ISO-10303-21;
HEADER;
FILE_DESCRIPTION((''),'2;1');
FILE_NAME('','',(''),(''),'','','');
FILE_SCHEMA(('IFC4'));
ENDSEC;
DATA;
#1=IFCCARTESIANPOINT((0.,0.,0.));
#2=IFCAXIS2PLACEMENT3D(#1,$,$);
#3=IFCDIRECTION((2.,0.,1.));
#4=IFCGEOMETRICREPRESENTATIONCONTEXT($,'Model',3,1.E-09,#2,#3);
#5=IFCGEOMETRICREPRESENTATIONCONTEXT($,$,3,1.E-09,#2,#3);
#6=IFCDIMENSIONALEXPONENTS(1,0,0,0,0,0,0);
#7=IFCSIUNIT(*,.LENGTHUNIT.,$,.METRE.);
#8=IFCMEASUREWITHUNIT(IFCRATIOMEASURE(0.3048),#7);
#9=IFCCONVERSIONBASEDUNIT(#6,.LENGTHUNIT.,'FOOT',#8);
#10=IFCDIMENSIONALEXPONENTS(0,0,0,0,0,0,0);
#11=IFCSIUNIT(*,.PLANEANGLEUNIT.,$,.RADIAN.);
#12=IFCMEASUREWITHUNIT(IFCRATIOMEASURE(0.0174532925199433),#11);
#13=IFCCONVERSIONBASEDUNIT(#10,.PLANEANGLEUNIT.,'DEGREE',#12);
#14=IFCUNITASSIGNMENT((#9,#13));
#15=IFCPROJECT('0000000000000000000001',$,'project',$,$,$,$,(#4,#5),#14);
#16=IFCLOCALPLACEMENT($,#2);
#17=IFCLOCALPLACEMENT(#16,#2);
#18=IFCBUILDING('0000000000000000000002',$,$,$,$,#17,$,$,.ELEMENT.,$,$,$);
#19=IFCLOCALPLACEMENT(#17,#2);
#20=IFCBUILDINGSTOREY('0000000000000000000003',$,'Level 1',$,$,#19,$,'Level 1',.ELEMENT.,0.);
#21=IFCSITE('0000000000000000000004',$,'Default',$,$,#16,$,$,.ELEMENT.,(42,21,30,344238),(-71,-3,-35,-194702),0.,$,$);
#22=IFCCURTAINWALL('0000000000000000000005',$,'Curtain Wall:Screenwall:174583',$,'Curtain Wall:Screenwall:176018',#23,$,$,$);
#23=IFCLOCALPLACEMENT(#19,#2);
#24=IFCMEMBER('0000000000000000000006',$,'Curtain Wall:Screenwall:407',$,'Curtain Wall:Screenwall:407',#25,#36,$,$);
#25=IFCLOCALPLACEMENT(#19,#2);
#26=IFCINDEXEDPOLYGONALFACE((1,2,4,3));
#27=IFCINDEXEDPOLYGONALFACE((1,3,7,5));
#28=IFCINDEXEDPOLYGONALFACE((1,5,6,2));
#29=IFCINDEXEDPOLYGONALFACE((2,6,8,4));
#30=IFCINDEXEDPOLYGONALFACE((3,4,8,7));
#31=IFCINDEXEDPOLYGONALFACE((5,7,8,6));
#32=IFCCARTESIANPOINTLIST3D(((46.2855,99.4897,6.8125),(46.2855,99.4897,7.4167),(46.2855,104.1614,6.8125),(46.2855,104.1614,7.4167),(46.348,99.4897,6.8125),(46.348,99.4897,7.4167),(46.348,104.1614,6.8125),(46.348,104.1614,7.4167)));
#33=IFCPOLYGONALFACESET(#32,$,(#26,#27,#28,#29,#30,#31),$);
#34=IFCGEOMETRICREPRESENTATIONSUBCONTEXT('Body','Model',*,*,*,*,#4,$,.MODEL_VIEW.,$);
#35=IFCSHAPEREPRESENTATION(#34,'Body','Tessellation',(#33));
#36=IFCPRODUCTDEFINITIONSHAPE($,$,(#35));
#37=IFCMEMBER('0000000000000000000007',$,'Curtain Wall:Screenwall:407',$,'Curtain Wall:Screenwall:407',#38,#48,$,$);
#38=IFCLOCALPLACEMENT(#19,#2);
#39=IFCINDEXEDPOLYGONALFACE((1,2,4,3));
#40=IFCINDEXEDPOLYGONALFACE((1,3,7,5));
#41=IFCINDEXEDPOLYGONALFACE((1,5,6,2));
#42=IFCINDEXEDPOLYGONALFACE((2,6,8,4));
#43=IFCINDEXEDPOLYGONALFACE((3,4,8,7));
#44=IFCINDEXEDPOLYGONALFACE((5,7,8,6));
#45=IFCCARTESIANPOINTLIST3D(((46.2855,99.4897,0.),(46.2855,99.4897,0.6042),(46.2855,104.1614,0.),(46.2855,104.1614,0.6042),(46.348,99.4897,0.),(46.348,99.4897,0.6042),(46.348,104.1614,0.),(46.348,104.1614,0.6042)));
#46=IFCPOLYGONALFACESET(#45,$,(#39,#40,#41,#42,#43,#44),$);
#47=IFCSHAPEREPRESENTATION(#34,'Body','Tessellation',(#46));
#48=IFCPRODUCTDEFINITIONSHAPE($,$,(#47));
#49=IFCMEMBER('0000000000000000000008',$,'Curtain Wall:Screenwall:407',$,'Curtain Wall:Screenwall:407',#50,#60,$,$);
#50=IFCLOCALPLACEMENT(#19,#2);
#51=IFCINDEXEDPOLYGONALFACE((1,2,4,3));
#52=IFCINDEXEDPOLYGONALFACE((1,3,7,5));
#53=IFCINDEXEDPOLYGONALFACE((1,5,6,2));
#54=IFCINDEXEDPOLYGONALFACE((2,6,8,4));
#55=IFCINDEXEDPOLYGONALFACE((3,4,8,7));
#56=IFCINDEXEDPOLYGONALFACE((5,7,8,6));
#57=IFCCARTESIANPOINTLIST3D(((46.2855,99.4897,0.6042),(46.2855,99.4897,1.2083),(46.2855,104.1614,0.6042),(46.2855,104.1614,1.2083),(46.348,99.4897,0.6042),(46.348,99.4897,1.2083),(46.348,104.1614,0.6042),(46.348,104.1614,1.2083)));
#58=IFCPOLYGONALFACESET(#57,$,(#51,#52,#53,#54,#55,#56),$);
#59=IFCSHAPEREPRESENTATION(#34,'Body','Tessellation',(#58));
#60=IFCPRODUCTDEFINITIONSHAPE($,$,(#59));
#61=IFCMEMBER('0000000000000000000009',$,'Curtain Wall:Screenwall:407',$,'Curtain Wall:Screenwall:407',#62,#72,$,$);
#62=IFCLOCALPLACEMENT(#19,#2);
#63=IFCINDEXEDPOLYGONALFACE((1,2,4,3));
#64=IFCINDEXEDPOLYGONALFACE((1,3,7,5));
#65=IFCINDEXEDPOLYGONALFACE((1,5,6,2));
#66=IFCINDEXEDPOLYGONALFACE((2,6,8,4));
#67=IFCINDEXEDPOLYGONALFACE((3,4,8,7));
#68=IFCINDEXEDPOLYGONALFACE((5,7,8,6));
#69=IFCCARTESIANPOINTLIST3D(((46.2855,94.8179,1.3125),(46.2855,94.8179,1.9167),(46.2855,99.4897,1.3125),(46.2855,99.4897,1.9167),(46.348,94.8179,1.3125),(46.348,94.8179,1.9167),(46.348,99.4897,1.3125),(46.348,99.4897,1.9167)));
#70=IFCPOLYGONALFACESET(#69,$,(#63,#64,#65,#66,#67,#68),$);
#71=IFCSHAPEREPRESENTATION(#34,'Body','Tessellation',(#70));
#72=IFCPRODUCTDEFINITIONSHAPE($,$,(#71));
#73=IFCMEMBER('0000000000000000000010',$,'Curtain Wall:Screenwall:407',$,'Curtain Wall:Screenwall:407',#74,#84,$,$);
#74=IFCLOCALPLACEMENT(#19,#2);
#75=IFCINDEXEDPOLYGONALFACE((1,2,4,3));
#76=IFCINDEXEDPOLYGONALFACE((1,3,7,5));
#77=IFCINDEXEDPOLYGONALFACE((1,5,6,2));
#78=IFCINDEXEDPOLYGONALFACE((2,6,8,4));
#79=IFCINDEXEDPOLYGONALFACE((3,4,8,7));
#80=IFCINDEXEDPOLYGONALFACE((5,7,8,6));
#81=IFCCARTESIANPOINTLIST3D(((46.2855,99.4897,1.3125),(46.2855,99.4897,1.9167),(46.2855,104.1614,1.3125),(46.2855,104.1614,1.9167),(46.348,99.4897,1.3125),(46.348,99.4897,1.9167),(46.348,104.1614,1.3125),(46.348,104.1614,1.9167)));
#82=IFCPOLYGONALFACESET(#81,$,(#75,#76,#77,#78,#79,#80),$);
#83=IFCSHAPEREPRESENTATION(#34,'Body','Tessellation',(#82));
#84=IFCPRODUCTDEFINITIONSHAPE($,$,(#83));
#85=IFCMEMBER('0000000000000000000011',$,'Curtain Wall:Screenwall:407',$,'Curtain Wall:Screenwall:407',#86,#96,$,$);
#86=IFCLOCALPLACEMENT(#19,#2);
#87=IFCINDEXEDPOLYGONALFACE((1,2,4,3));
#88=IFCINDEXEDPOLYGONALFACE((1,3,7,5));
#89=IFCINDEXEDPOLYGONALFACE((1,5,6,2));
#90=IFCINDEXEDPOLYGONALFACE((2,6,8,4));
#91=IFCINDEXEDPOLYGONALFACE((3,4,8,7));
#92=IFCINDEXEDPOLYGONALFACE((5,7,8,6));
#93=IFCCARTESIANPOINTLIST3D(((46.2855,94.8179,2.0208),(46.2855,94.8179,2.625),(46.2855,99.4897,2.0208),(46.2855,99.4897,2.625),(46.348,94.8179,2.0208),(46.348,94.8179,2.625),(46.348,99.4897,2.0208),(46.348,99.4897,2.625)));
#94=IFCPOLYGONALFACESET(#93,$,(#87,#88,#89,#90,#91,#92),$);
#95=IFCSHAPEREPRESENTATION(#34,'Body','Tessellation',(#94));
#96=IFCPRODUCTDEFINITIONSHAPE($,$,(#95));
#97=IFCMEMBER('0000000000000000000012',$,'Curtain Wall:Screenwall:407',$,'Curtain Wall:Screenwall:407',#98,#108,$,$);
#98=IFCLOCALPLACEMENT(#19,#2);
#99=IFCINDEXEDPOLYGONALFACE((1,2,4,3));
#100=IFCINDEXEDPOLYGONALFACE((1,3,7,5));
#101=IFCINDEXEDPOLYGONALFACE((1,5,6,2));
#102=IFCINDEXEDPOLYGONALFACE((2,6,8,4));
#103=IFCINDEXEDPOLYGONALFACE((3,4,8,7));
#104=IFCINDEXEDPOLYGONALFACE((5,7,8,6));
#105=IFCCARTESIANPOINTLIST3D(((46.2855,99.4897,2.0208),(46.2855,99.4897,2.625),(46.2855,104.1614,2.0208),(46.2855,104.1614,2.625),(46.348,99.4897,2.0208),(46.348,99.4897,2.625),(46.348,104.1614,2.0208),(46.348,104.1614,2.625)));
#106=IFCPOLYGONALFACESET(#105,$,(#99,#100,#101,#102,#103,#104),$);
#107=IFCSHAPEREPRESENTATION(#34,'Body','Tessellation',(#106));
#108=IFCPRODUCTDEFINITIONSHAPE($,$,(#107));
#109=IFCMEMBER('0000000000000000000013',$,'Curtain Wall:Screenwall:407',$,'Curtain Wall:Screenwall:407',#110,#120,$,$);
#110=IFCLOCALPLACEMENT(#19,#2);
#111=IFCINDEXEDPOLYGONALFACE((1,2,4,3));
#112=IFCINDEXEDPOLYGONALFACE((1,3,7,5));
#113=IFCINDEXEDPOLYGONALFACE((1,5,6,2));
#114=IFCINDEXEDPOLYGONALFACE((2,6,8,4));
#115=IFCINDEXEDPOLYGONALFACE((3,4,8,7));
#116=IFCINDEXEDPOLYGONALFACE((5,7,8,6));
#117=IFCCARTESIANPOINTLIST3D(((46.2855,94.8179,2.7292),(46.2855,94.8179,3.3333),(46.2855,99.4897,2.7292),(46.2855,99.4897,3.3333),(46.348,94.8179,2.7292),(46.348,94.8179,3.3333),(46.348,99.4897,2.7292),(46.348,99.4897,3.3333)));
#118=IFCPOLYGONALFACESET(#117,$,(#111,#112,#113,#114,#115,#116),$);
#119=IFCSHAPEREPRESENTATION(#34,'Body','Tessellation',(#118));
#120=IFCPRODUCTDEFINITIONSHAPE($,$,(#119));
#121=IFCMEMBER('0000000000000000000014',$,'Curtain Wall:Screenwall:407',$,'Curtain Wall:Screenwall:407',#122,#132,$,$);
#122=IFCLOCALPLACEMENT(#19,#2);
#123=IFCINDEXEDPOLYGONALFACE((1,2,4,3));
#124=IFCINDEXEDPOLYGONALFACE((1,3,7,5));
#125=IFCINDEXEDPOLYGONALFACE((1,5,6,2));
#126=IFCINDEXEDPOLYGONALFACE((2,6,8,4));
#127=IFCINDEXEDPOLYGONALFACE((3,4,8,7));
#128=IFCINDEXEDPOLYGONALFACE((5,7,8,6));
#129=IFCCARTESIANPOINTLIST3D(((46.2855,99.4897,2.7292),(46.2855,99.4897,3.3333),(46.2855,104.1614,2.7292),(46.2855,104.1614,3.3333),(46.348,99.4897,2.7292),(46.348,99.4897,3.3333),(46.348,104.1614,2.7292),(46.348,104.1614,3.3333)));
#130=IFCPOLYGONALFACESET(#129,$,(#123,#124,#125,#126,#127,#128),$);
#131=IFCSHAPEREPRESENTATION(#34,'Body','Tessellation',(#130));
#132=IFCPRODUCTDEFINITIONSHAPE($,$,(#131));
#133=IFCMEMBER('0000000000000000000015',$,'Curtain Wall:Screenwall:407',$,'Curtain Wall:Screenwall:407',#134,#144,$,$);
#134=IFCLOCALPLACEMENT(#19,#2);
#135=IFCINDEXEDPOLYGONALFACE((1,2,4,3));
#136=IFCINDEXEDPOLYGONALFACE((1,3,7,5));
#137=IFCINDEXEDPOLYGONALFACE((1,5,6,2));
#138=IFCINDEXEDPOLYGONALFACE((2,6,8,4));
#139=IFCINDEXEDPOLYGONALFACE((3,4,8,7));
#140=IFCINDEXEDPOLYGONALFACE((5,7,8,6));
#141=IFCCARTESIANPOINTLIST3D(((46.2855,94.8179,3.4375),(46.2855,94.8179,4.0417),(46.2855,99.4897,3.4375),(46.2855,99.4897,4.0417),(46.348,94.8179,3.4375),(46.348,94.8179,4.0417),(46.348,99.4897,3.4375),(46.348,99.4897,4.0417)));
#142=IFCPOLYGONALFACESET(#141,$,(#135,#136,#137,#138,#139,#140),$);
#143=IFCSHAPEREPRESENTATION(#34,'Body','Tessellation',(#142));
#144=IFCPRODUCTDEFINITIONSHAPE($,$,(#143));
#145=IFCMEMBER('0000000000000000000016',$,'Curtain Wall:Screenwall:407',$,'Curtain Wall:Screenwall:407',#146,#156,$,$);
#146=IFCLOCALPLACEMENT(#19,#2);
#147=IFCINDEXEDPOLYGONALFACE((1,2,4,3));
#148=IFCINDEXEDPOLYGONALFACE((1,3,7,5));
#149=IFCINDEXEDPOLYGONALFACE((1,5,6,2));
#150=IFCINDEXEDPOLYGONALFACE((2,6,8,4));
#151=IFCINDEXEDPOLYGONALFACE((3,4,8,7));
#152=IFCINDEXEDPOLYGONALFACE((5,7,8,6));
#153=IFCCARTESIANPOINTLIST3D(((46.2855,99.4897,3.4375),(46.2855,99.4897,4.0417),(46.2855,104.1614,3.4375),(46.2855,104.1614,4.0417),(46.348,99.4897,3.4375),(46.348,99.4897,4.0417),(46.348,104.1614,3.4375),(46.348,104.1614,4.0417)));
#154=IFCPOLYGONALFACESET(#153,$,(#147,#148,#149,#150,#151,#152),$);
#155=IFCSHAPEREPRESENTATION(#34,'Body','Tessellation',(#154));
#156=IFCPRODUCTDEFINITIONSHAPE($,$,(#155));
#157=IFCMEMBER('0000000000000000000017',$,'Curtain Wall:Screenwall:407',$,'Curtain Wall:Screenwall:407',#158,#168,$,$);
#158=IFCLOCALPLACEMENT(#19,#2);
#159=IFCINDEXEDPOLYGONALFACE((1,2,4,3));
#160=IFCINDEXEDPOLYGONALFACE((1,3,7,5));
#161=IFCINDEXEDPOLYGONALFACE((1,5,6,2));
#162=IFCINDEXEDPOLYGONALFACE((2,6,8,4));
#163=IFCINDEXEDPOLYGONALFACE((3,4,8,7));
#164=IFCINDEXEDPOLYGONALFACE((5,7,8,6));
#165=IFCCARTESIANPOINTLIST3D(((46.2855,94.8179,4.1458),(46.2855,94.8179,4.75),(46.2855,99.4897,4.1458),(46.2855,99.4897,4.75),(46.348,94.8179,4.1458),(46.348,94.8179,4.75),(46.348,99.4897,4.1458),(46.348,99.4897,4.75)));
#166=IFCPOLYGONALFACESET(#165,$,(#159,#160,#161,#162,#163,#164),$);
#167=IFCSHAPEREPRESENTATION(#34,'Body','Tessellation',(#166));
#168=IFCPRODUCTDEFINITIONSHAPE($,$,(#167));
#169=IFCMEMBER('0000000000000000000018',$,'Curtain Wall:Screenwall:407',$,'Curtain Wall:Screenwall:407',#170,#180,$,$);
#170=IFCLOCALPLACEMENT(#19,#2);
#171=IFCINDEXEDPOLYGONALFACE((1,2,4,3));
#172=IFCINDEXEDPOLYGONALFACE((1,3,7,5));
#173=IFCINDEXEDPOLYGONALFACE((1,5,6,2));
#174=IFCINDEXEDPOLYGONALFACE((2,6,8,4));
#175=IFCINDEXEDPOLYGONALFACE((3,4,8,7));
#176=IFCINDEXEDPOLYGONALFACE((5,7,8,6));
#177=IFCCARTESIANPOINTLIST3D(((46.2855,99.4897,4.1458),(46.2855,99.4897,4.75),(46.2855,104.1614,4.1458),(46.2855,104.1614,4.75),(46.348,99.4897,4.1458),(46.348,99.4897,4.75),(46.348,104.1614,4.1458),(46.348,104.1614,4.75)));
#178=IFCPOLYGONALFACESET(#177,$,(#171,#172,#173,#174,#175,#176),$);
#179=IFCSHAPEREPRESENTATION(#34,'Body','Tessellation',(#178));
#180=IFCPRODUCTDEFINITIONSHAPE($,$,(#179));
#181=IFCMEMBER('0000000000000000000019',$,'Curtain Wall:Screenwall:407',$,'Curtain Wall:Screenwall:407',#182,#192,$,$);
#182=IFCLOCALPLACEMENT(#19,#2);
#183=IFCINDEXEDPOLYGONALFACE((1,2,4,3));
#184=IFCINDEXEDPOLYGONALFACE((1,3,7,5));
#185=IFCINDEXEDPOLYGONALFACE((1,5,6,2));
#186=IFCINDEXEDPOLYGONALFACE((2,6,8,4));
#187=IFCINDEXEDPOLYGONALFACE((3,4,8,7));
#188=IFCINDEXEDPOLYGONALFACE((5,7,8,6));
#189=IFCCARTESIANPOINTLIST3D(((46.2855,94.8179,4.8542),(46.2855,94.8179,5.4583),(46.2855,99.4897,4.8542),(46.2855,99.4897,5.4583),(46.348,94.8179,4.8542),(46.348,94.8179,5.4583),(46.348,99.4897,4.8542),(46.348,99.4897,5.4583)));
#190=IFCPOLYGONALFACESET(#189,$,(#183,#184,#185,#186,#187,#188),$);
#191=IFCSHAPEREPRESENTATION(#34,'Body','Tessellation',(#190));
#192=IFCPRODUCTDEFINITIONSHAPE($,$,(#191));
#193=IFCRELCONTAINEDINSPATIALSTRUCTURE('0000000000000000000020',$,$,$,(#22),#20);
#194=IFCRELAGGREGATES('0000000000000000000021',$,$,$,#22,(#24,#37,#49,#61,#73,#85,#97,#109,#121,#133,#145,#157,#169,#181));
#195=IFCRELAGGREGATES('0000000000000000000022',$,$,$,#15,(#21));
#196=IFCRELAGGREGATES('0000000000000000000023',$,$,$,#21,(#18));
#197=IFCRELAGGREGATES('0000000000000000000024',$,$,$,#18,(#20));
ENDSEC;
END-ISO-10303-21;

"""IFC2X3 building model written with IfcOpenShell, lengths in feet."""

from ifc_helpers import new_model, entity, si_unit, converted_unit, direction, frame, frame_2d, origin, place, context, subcontext, project, spatial, rectangle, extrude, element, aggregate, save


model = new_model("IFC2X3")

# Units and contexts
model_context = context("Model", 3, precision=1e-09, world=origin(), true_north=direction((2.0, 0.0, 1.0)))
context_of_model = context(None, 3, precision=1e-09, world=origin(), true_north=direction((2.0, 0.0, 1.0)))
body_context = subcontext(model_context, "Body", "Model", "MODEL_VIEW")
ifc_project = project(units=[converted_unit("LENGTHUNIT", "FOOT", entity("IfcRatioMeasure", 0.3048), si_unit("LENGTHUNIT", "METRE"), dimensions=[1, 0, 0, 0, 0, 0, 0]), converted_unit("PLANEANGLEUNIT", "DEGREE", entity("IfcRatioMeasure", 0.0174532925199433), si_unit("PLANEANGLEUNIT", "RADIAN"), dimensions=[0, 0, 0, 0, 0, 0, 0])], contexts=[model_context, context_of_model])

# Site, building, storey
site_placement = place(None, origin())
site = spatial("IfcSite", under=ifc_project, at=site_placement, Name="Default", CompositionType="ELEMENT", RefLatitude=(42, 21, 30, 344238), RefLongitude=(-71, -3, -35, -194702), RefElevation=0.0)
building_placement = place(site_placement, origin())
building = spatial("IfcBuilding", under=site, at=building_placement, CompositionType="ELEMENT")
storey_placement = place(building_placement, origin())
storey = spatial("IfcBuildingStorey", under=building, at=storey_placement, Name="Level 1", LongName="Level 1", CompositionType="ELEMENT", Elevation=0.0)

# Curtain wall, members
curtain_wall_1_placement = place(storey_placement, origin())
curtain_wall_1 = element("IfcCurtainWall", 1, at=curtain_wall_1_placement, inside=storey, Name="Curtain Wall:Screenwall:174583", ObjectType="Curtain Wall:Screenwall:176018")
member_1_placement = place(curtain_wall_1_placement, frame((46.2855, 99.4897, 6.8125)))
member_1 = element("IfcMember", 2, at=member_1_placement, Name="Curtain Wall:Screenwall:407", ObjectType="Curtain Wall:Screenwall:407", context=body_context, shape_type="SweptSolid", body=[
    extrude(rectangle(XDim=4.6717, YDim=0.0625, at=frame_2d((0.0, 0.0), x_axis=(1.0, 0.0))), frame((0.0313, 2.3359, 0.0), z_axis=(0.0, 0.0, 1.0), x_axis=(0.0, -1.0, 0.0)), (0.0, 0.0, 1.0), 0.6042),
])
member_2_placement = place(curtain_wall_1_placement, frame((46.2855, 99.4897, 0.0)))
member_2 = element("IfcMember", 3, at=member_2_placement, Name="Curtain Wall:Screenwall:407", ObjectType="Curtain Wall:Screenwall:407", context=body_context, shape_type="SweptSolid", body=[
    extrude(rectangle(XDim=4.6717, YDim=0.0625, at=frame_2d((0.0, 0.0), x_axis=(1.0, 0.0))), frame((0.0312, 2.3359, 0.0), z_axis=(0.0, 0.0, 1.0), x_axis=(0.0, 1.0, 0.0)), (0.0, 0.0, 1.0), 0.6042),
])
member_3_placement = place(curtain_wall_1_placement, frame((46.2855, 99.4897, 0.6042)))
member_3 = element("IfcMember", 4, at=member_3_placement, Name="Curtain Wall:Screenwall:407", ObjectType="Curtain Wall:Screenwall:407", context=body_context, shape_type="SweptSolid", body=[
    extrude(rectangle(XDim=4.6717, YDim=0.0625, at=frame_2d((0.0, 0.0), x_axis=(1.0, 0.0))), frame((0.0313, 2.3359, 0.0), z_axis=(0.0, 0.0, 1.0), x_axis=(0.0, -1.0, 0.0)), (0.0, 0.0, 1.0), 0.6042),
])
member_4_placement = place(curtain_wall_1_placement, frame((46.2855, 94.8179, 1.3125)))
member_4 = element("IfcMember", 5, at=member_4_placement, Name="Curtain Wall:Screenwall:407", ObjectType="Curtain Wall:Screenwall:407", context=body_context, shape_type="SweptSolid", body=[
    extrude(rectangle(XDim=4.6717, YDim=0.0625, at=frame_2d((0.0, 0.0), x_axis=(1.0, 0.0))), frame((0.0312, 2.3359, 0.0), z_axis=(0.0, 0.0, 1.0), x_axis=(0.0, -1.0, 0.0)), (0.0, 0.0, 1.0), 0.6042),
])
member_5_placement = place(curtain_wall_1_placement, frame((46.2855, 99.4897, 1.3125)))
member_5 = element("IfcMember", 6, at=member_5_placement, Name="Curtain Wall:Screenwall:407", ObjectType="Curtain Wall:Screenwall:407", context=body_context, shape_type="SweptSolid", body=[
    extrude(rectangle(XDim=4.6717, YDim=0.0625, at=frame_2d((0.0, 0.0), x_axis=(1.0, 0.0))), frame((0.0313, 2.3359, 0.0), z_axis=(0.0, 0.0, 1.0), x_axis=(0.0, -1.0, 0.0)), (0.0, 0.0, 1.0), 0.6042),
])
member_6_placement = place(curtain_wall_1_placement, frame((46.2855, 94.8179, 2.0208)))
member_6 = element("IfcMember", 7, at=member_6_placement, Name="Curtain Wall:Screenwall:407", ObjectType="Curtain Wall:Screenwall:407", context=body_context, shape_type="SweptSolid", body=[
    extrude(rectangle(XDim=4.6717, YDim=0.0625, at=frame_2d((0.0, 0.0), x_axis=(1.0, 0.0))), frame((0.0312, 2.3359, 0.0), z_axis=(0.0, 0.0, 1.0), x_axis=(0.0, -1.0, 0.0)), (0.0, 0.0, 1.0), 0.6042),
])
member_7_placement = place(curtain_wall_1_placement, frame((46.2855, 99.4897, 2.0208)))
member_7 = element("IfcMember", 8, at=member_7_placement, Name="Curtain Wall:Screenwall:407", ObjectType="Curtain Wall:Screenwall:407", context=body_context, shape_type="SweptSolid", body=[
    extrude(rectangle(XDim=4.6717, YDim=0.0625, at=frame_2d((0.0, 0.0), x_axis=(1.0, 0.0))), frame((0.0313, 2.3359, 0.0), z_axis=(0.0, 0.0, 1.0), x_axis=(0.0, -1.0, 0.0)), (0.0, 0.0, 1.0), 0.6042),
])
member_8_placement = place(curtain_wall_1_placement, frame((46.2855, 94.8179, 2.7292)))
member_8 = element("IfcMember", 9, at=member_8_placement, Name="Curtain Wall:Screenwall:407", ObjectType="Curtain Wall:Screenwall:407", context=body_context, shape_type="SweptSolid", body=[
    extrude(rectangle(XDim=4.6717, YDim=0.0625, at=frame_2d((0.0, 0.0), x_axis=(1.0, 0.0))), frame((0.0312, 2.3359, 0.0), z_axis=(0.0, 0.0, 1.0), x_axis=(0.0, -1.0, 0.0)), (0.0, 0.0, 1.0), 0.6042),
])
member_9_placement = place(curtain_wall_1_placement, frame((46.2855, 99.4897, 2.7292)))
member_9 = element("IfcMember", 10, at=member_9_placement, Name="Curtain Wall:Screenwall:407", ObjectType="Curtain Wall:Screenwall:407", context=body_context, shape_type="SweptSolid", body=[
    extrude(rectangle(XDim=4.6717, YDim=0.0625, at=frame_2d((0.0, 0.0), x_axis=(1.0, 0.0))), frame((0.0313, 2.3359, 0.0), z_axis=(0.0, 0.0, 1.0), x_axis=(0.0, -1.0, 0.0)), (0.0, 0.0, 1.0), 0.6042),
])
member_10_placement = place(curtain_wall_1_placement, frame((46.2855, 94.8179, 3.4375)))
member_10 = element("IfcMember", 11, at=member_10_placement, Name="Curtain Wall:Screenwall:407", ObjectType="Curtain Wall:Screenwall:407", context=body_context, shape_type="SweptSolid", body=[
    extrude(rectangle(XDim=4.6717, YDim=0.0625, at=frame_2d((0.0, 0.0), x_axis=(1.0, 0.0))), frame((0.0312, 2.3359, 0.0), z_axis=(0.0, 0.0, 1.0), x_axis=(0.0, -1.0, 0.0)), (0.0, 0.0, 1.0), 0.6042),
])
member_11_placement = place(curtain_wall_1_placement, frame((46.2855, 99.4897, 3.4375)))
member_11 = element("IfcMember", 12, at=member_11_placement, Name="Curtain Wall:Screenwall:407", ObjectType="Curtain Wall:Screenwall:407", context=body_context, shape_type="SweptSolid", body=[
    extrude(rectangle(XDim=4.6717, YDim=0.0625, at=frame_2d((0.0, 0.0), x_axis=(1.0, 0.0))), frame((0.0313, 2.3359, 0.0), z_axis=(0.0, 0.0, 1.0), x_axis=(0.0, -1.0, 0.0)), (0.0, 0.0, 1.0), 0.6042),
])
member_12_placement = place(curtain_wall_1_placement, frame((46.2855, 94.8179, 4.1458)))
member_12 = element("IfcMember", 13, at=member_12_placement, Name="Curtain Wall:Screenwall:407", ObjectType="Curtain Wall:Screenwall:407", context=body_context, shape_type="SweptSolid", body=[
    extrude(rectangle(XDim=4.6717, YDim=0.0625, at=frame_2d((0.0, 0.0), x_axis=(1.0, 0.0))), frame((0.0312, 2.3359, 0.0), z_axis=(0.0, 0.0, 1.0), x_axis=(0.0, -1.0, 0.0)), (0.0, 0.0, 1.0), 0.6042),
])
member_13_placement = place(curtain_wall_1_placement, frame((46.2855, 99.4897, 4.1458)))
member_13 = element("IfcMember", 14, at=member_13_placement, Name="Curtain Wall:Screenwall:407", ObjectType="Curtain Wall:Screenwall:407", context=body_context, shape_type="SweptSolid", body=[
    extrude(rectangle(XDim=4.6717, YDim=0.0625, at=frame_2d((0.0, 0.0), x_axis=(1.0, 0.0))), frame((0.0313, 2.3359, 0.0), z_axis=(0.0, 0.0, 1.0), x_axis=(0.0, -1.0, 0.0)), (0.0, 0.0, 1.0), 0.6042),
])
member_14_placement = place(curtain_wall_1_placement, frame((46.2855, 94.8179, 4.8542)))
member_14 = element("IfcMember", 15, at=member_14_placement, Name="Curtain Wall:Screenwall:407", ObjectType="Curtain Wall:Screenwall:407", context=body_context, shape_type="SweptSolid", body=[
    extrude(rectangle(XDim=4.6717, YDim=0.0625, at=frame_2d((0.0, 0.0), x_axis=(1.0, 0.0))), frame((0.0312, 2.3359, 0.0), z_axis=(0.0, 0.0, 1.0), x_axis=(0.0, -1.0, 0.0)), (0.0, 0.0, 1.0), 0.6042),
])
aggregate(curtain_wall_1, [member_1, member_2, member_3, member_4, member_5, member_6, member_7, member_8, member_9, member_10, member_11, member_12, member_13, member_14])

save(model, "model.ifc")
